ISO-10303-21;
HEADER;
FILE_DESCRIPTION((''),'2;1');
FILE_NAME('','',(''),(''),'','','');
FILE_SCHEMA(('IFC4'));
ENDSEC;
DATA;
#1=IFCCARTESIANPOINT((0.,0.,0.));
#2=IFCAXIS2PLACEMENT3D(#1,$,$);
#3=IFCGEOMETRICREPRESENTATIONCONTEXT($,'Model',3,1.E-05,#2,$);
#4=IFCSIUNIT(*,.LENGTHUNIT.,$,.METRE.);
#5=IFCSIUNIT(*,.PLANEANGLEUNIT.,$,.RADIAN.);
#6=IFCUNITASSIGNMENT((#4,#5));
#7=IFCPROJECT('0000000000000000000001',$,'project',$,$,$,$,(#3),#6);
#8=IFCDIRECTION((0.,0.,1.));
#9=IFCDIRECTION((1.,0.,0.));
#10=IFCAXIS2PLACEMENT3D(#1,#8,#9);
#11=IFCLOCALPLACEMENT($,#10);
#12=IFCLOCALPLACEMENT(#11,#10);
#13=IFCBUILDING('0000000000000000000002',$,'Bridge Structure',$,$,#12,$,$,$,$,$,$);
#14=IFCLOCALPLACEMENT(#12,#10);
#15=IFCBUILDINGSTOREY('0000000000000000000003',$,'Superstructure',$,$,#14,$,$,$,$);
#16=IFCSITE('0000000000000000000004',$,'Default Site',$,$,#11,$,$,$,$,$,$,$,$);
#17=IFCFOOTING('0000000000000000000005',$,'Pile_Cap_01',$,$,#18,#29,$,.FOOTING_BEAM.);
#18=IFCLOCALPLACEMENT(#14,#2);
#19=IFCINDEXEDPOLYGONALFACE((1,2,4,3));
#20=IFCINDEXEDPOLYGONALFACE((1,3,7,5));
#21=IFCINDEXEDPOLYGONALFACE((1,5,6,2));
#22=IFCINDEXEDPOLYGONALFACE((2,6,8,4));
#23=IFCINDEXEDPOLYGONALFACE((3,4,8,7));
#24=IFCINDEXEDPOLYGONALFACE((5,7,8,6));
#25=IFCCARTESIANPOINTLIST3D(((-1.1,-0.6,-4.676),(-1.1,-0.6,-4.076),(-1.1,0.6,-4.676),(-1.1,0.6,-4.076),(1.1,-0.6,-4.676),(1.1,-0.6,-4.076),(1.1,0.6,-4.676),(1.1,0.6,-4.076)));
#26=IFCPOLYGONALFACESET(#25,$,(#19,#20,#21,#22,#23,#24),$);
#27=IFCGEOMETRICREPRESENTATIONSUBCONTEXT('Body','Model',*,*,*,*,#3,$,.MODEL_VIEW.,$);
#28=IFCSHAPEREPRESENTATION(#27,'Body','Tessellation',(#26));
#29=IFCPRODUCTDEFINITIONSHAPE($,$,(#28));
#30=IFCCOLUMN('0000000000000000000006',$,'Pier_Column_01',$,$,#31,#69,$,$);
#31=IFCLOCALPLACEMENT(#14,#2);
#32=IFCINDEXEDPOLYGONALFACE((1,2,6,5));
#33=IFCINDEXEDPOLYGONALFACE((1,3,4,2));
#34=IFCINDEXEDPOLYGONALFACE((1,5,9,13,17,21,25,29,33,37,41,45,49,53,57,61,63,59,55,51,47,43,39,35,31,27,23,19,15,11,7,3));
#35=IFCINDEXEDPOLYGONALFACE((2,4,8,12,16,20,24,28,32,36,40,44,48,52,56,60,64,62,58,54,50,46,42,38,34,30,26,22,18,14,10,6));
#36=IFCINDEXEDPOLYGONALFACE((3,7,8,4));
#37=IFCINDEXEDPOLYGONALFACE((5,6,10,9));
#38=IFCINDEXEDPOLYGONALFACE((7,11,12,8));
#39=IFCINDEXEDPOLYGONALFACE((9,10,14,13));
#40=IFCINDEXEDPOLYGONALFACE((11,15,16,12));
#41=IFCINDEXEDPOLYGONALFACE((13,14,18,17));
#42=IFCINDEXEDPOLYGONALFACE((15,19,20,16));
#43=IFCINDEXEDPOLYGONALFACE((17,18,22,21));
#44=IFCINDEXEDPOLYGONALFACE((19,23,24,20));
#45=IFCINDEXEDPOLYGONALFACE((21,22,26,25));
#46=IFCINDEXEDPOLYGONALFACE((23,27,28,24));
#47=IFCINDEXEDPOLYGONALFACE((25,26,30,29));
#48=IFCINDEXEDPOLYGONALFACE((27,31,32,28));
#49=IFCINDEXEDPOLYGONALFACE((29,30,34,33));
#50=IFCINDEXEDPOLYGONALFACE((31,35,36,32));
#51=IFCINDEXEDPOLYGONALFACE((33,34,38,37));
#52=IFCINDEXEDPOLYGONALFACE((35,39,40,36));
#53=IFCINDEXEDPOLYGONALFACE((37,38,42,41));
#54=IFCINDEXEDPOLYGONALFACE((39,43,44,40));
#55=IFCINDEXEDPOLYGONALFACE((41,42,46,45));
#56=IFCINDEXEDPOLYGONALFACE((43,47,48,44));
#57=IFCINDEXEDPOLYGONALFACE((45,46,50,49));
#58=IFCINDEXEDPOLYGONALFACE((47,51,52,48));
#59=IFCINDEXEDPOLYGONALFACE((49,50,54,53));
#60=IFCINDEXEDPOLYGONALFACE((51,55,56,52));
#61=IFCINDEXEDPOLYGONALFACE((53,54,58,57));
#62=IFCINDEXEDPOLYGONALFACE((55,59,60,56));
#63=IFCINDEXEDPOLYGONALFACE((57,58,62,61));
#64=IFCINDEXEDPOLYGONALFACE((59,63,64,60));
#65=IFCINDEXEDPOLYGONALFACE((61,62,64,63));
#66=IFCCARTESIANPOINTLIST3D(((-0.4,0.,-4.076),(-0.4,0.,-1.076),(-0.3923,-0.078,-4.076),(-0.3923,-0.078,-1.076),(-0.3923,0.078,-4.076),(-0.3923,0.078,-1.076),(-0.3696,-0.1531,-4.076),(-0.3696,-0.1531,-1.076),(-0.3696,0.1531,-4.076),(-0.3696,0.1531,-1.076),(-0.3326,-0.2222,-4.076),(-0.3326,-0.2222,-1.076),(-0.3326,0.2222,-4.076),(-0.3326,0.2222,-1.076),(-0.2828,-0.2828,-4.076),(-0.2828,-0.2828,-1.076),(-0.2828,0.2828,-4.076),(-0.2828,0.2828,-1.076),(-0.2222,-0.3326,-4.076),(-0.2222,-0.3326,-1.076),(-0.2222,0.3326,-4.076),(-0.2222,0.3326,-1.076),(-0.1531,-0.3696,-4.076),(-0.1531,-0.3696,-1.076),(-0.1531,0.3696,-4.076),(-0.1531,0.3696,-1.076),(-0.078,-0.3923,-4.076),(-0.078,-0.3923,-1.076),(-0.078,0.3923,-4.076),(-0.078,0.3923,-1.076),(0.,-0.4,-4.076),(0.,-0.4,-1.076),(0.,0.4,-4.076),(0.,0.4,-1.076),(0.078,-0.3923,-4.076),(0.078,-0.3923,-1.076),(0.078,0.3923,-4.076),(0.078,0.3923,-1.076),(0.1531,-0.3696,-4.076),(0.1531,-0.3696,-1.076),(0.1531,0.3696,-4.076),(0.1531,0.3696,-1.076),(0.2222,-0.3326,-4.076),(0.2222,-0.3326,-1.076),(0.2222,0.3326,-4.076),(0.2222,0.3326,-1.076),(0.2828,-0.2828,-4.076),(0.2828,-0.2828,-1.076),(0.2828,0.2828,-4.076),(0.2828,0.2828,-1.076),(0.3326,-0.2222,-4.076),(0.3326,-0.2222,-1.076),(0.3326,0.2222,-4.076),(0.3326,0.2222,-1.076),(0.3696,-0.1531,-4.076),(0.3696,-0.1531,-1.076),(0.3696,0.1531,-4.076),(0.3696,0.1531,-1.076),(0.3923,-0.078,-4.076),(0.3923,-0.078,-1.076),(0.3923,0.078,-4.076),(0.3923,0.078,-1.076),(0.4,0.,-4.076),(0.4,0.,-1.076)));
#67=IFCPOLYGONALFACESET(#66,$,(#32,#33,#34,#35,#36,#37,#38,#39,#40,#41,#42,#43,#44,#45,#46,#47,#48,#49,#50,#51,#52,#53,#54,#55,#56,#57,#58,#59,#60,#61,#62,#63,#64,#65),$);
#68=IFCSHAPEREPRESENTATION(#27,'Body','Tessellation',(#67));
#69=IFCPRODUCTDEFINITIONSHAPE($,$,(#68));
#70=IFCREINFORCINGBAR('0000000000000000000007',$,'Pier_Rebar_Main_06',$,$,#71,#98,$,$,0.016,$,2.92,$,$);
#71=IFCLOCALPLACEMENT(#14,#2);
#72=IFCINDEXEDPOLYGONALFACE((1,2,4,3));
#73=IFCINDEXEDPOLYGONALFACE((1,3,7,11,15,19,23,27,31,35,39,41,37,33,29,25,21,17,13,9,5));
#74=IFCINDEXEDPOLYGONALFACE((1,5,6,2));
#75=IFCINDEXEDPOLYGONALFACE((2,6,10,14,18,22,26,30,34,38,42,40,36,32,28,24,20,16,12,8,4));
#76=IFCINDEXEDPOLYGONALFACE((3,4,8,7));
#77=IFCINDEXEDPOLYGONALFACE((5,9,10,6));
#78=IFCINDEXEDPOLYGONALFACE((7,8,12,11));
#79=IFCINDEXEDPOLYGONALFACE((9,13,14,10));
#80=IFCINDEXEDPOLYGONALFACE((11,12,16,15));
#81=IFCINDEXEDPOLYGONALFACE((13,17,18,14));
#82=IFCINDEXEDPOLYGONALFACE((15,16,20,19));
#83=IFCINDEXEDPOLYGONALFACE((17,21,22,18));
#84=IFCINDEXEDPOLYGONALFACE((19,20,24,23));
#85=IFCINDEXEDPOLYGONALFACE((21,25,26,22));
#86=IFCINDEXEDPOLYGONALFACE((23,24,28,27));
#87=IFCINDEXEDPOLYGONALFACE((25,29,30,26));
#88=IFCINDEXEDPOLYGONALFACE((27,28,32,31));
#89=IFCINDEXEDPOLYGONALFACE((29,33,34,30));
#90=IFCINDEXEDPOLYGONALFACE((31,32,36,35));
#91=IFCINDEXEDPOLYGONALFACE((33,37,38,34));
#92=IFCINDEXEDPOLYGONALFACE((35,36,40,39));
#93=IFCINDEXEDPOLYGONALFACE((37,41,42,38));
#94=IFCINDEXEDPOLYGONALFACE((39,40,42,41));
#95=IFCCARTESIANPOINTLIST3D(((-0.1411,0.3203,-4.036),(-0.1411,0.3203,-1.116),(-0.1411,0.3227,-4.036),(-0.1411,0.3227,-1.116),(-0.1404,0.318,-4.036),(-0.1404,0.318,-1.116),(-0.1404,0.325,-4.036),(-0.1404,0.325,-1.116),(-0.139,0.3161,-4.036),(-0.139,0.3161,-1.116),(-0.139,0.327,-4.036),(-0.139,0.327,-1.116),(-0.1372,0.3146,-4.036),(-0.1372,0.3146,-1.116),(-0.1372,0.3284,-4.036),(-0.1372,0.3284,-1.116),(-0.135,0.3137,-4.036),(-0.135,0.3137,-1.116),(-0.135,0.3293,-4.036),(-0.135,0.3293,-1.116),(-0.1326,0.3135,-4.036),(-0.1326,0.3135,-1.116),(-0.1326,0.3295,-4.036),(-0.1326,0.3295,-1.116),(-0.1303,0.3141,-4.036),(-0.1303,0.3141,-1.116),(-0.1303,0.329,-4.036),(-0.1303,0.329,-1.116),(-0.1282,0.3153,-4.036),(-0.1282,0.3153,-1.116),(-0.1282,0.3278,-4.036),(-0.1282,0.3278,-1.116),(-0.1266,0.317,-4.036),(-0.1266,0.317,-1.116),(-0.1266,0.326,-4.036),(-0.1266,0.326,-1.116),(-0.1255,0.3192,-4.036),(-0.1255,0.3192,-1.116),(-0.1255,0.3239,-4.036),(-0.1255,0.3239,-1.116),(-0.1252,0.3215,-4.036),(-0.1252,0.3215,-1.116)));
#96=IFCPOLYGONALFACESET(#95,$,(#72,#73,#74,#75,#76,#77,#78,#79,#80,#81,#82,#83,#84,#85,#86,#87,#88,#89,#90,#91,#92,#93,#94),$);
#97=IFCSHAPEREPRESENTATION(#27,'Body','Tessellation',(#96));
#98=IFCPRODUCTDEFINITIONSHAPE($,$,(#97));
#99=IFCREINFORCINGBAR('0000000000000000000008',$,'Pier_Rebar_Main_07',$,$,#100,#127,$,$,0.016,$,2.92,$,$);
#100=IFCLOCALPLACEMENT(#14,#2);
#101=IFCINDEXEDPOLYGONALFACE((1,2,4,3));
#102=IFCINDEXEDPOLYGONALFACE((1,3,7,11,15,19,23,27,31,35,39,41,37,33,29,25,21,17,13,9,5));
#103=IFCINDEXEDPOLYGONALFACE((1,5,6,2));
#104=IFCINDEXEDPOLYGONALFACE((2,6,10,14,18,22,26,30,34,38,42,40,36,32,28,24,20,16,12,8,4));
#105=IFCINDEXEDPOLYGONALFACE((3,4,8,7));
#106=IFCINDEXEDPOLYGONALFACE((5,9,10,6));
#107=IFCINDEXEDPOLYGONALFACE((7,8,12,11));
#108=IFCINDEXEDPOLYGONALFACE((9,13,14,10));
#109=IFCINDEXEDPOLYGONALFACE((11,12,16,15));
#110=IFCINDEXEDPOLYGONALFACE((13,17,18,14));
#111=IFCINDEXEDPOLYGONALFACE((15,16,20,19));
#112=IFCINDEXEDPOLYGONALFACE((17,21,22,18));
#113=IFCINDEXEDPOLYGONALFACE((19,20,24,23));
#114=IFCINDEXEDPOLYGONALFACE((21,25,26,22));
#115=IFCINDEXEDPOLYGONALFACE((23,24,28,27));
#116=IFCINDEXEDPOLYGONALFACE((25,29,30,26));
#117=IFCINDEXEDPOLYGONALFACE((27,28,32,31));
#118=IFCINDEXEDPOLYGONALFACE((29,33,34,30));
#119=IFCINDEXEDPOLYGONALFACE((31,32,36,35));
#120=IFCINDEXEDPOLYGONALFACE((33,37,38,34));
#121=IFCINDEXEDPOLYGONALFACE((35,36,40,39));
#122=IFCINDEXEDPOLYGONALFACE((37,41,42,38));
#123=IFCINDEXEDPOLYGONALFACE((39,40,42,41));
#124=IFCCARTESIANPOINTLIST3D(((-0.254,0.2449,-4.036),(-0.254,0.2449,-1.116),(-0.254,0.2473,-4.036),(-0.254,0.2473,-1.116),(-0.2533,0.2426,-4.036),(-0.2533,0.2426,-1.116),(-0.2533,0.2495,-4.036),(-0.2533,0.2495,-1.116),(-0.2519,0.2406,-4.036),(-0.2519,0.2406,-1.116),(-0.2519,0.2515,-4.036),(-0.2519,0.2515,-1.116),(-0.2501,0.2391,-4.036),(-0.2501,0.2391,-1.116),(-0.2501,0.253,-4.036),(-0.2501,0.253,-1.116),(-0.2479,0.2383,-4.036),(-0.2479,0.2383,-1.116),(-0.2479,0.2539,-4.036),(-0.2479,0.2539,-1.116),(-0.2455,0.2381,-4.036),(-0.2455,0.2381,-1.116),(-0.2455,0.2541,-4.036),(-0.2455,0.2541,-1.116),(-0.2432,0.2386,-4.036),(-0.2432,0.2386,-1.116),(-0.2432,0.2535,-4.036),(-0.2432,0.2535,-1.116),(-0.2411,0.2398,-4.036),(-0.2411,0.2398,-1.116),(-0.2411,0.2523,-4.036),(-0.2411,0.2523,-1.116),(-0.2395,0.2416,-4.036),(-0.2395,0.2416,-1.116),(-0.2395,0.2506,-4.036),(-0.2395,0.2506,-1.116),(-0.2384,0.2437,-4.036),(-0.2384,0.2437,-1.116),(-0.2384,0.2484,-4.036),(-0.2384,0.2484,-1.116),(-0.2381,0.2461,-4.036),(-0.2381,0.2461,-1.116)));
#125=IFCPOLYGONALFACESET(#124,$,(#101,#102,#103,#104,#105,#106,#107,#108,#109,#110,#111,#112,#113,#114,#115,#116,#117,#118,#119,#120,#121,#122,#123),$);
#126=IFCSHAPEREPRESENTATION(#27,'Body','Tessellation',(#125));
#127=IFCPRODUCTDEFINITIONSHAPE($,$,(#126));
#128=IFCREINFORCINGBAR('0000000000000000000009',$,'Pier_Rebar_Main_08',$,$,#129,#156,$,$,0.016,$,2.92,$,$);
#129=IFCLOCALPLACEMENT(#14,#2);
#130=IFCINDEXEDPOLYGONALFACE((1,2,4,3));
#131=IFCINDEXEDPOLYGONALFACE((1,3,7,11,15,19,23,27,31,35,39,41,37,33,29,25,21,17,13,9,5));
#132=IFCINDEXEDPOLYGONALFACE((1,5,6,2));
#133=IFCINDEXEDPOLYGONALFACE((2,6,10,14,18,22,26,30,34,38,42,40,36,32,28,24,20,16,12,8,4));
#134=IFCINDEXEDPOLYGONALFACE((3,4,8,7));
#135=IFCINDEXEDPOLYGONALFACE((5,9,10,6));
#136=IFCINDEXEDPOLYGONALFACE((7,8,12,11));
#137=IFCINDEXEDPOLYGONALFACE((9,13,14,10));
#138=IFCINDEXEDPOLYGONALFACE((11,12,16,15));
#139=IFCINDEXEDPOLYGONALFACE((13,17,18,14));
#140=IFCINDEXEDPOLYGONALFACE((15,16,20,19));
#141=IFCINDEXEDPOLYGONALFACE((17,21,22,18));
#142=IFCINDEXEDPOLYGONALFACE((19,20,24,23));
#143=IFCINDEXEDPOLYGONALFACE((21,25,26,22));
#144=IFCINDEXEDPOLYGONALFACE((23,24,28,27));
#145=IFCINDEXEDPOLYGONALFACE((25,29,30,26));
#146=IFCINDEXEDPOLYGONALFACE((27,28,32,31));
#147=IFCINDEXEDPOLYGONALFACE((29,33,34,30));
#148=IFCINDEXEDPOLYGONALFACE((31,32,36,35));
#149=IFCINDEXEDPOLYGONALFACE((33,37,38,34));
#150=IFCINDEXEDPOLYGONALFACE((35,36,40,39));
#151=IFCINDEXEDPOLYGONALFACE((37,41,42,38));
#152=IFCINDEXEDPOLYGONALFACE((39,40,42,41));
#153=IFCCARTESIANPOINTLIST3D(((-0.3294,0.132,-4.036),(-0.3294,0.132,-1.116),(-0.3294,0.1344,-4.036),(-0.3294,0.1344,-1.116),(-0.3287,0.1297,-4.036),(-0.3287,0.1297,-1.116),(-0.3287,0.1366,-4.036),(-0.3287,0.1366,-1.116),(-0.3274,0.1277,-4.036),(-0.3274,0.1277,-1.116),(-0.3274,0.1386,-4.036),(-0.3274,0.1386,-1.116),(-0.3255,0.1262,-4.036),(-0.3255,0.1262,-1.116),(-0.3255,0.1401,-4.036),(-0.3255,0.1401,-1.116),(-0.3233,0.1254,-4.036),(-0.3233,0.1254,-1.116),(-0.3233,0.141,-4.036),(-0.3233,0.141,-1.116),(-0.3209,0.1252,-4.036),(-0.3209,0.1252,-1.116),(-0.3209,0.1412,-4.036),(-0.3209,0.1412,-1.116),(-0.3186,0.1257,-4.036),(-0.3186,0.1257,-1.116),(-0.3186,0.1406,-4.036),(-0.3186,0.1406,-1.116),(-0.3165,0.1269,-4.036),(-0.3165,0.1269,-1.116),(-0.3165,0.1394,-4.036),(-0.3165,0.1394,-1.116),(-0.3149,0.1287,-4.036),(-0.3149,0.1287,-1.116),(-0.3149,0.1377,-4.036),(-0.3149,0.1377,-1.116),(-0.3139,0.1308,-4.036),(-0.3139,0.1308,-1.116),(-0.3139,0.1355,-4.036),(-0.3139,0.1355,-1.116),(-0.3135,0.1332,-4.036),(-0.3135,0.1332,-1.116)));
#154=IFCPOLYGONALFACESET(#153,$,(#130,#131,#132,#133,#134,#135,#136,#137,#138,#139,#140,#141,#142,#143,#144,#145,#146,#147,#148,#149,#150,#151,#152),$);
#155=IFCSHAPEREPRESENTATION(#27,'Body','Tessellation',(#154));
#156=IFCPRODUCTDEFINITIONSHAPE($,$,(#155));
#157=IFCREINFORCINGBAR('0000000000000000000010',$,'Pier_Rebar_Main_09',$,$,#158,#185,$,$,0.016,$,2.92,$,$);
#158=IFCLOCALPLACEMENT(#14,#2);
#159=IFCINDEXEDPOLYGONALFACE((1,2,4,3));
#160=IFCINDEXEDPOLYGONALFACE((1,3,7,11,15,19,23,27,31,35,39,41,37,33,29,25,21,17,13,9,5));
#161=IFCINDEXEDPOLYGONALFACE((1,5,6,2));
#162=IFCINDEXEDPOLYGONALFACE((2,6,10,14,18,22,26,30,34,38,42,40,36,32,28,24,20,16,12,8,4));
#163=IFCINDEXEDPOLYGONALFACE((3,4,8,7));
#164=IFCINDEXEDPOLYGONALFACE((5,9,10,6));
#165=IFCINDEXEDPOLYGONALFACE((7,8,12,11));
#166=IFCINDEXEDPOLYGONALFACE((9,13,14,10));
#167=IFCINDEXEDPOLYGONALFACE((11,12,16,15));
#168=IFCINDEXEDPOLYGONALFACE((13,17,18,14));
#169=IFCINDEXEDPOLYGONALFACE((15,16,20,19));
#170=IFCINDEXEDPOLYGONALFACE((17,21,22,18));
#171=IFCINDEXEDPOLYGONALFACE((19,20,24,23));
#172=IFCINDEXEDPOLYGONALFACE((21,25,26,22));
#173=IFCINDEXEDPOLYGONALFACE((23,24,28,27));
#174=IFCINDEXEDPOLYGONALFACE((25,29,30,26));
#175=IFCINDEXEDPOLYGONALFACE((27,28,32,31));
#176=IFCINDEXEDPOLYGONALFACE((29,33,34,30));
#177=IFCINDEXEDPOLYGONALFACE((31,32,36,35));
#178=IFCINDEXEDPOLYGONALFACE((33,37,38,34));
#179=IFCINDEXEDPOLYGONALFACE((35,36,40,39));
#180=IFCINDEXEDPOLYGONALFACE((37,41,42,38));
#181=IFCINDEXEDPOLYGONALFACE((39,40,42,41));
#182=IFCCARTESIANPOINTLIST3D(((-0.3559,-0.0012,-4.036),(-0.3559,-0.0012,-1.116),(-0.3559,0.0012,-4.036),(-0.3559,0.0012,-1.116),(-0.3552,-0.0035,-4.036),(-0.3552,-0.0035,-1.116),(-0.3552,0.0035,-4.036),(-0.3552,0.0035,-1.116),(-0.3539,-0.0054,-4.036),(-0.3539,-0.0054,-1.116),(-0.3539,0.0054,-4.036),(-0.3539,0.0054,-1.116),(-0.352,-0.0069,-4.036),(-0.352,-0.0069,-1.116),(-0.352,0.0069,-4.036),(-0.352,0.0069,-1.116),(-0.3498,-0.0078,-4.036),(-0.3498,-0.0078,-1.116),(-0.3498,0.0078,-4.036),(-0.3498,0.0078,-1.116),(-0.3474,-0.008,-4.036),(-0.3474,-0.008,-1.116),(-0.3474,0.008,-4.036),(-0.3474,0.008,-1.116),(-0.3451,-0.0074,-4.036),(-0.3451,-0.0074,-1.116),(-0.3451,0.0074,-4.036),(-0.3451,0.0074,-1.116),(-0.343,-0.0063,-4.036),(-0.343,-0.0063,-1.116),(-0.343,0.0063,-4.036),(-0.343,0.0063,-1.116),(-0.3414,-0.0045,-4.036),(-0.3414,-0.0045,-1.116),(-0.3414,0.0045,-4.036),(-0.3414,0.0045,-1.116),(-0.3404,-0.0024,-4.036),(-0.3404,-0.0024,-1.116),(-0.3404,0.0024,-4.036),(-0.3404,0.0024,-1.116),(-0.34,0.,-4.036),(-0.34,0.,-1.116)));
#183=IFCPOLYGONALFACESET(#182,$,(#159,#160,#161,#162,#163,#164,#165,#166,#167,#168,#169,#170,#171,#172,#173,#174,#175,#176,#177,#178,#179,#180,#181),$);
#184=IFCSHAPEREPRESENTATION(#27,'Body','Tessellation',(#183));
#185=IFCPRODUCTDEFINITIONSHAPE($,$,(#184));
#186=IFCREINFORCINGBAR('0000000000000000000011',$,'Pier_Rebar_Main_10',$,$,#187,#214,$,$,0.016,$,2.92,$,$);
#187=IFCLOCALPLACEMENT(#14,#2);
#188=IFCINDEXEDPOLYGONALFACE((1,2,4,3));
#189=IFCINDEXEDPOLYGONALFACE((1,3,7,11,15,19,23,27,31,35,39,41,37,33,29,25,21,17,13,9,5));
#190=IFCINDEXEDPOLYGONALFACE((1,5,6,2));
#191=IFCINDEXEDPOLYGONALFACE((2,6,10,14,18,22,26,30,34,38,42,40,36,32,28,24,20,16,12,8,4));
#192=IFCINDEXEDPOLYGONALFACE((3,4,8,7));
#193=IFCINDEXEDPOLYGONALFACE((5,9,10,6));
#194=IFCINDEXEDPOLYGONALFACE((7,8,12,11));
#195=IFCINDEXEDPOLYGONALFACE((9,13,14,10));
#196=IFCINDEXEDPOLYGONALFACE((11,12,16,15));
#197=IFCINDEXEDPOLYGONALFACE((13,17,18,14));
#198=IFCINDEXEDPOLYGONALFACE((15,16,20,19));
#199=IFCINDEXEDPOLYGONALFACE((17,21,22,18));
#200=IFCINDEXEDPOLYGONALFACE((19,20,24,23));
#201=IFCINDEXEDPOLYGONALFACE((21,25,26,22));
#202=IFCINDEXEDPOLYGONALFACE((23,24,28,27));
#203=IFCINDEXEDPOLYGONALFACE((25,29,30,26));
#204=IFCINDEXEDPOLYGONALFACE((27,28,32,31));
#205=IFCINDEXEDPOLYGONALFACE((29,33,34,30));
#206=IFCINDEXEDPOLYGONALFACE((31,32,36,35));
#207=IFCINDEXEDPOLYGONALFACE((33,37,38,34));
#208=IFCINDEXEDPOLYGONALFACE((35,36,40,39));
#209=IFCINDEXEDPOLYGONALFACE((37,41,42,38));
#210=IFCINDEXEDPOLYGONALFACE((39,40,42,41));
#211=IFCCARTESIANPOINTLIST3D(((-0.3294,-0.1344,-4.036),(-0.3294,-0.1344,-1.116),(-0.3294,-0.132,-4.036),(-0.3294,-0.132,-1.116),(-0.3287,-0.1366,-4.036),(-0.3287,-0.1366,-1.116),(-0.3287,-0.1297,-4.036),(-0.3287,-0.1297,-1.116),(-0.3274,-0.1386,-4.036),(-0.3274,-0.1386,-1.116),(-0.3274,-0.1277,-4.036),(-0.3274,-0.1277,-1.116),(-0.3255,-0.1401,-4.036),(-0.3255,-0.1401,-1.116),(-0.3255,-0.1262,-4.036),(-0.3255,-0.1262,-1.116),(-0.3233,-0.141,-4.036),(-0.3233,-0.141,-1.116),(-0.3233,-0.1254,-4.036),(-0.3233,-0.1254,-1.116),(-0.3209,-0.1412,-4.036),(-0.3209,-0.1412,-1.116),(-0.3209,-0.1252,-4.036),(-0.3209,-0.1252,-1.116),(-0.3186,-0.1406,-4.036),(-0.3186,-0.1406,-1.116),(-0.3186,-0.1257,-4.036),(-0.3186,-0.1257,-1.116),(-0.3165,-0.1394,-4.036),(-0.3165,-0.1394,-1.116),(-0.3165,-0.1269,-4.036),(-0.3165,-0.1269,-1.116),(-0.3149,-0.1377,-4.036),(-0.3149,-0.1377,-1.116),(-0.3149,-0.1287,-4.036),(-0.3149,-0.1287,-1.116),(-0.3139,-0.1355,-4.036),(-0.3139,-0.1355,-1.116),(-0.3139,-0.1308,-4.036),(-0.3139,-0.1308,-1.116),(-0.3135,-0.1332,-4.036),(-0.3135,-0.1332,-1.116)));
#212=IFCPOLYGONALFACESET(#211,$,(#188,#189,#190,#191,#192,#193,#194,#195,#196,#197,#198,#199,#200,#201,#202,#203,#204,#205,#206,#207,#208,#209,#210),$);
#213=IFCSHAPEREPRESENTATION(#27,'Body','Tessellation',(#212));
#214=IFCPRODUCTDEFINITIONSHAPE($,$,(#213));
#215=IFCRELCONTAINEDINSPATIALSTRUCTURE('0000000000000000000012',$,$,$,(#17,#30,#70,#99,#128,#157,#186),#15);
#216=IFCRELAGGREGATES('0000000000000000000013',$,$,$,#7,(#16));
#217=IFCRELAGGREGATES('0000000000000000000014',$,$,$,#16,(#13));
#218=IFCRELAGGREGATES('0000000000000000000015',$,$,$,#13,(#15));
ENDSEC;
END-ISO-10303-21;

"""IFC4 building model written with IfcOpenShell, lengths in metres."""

from ifc_helpers import new_model, si_unit, frame, origin, origin_with_axes, origin_2d_with_axis, place, context, subcontext, project, spatial, rectangle, circle, extrude, element, save


model = new_model("IFC4")

# Units and contexts
model_context = context("Model", 3, precision=1e-05, world=origin())
body_context = subcontext(model_context, "Body", "Model", "MODEL_VIEW")
ifc_project = project(units=[si_unit("LENGTHUNIT", "METRE"), si_unit("PLANEANGLEUNIT", "RADIAN")], contexts=[model_context])

# Site, building, storey
site_placement = place(None, origin_with_axes())
site = spatial("IfcSite", under=ifc_project, at=site_placement, Name="Default Site")
building_placement = place(site_placement, origin_with_axes())
building = spatial("IfcBuilding", under=site, at=building_placement, Name="Bridge Structure")
storey_placement = place(building_placement, origin_with_axes())
storey = spatial("IfcBuildingStorey", under=building, at=storey_placement, Name="Superstructure")

# Footing
footing_placement = place(storey_placement, frame((0.0, 0.0, -4.676), z_axis=(0.0, 0.0, 1.0), x_axis=(1.0, 0.0, 0.0)))
element("IfcFooting", 1, at=footing_placement, inside=storey, Name="Pile_Cap_01", PredefinedType="FOOTING_BEAM", context=body_context, shape_type="SweptSolid", body=[
    extrude(rectangle(XDim=2.2, YDim=1.2, at=origin_2d_with_axis()), origin_with_axes(), (0.0, 0.0, 1.0), 0.6),
])

# Column
column_placement = place(storey_placement, frame((0.0, 0.0, -4.076), z_axis=(0.0, 0.0, 1.0), x_axis=(1.0, 0.0, 0.0)))
element("IfcColumn", 2, at=column_placement, inside=storey, Name="Pier_Column_01", context=body_context, shape_type="SweptSolid", body=[
    extrude(circle(Radius=0.4, at=origin_2d_with_axis()), origin_with_axes(), (0.0, 0.0, 1.0), 3.0),
])

# Reinforcing bars
for number, where, z_axis, x_axis, name in (
    (3, (-0.1332, 0.3215, -4.036), (0.0, 0.0, 1.0), (1.0, 0.0, 0.0), "Pier_Rebar_Main_06"),
    (4, (-0.2461, 0.2461, -4.036), (0.0, 0.0, 1.0), (1.0, 0.0, 0.0), "Pier_Rebar_Main_07"),
    (5, (-0.3215, 0.1332, -4.036), (0.0, 0.0, 1.0), (1.0, 0.0, 0.0), "Pier_Rebar_Main_08"),
    (6, (-0.348, 0.0, -4.036), (0.0, 0.0, 1.0), (1.0, 0.0, 0.0), "Pier_Rebar_Main_09"),
    (7, (-0.3215, -0.1332, -4.036), (0.0, 0.0, 1.0), (1.0, 0.0, 0.0), "Pier_Rebar_Main_10"),
):
    element("IfcReinforcingBar", number, at=place(storey_placement, frame(where, z_axis=z_axis, x_axis=x_axis)), inside=storey, Name=name, BarLength=2.92, NominalDiameter=0.016, context=body_context, shape_type="SweptSolid", body=[
        extrude(circle(Radius=0.008, at=origin_2d_with_axis()), origin_with_axes(), (0.0, 0.0, 1.0), 2.92),
    ])

save(model, "model.ifc")
